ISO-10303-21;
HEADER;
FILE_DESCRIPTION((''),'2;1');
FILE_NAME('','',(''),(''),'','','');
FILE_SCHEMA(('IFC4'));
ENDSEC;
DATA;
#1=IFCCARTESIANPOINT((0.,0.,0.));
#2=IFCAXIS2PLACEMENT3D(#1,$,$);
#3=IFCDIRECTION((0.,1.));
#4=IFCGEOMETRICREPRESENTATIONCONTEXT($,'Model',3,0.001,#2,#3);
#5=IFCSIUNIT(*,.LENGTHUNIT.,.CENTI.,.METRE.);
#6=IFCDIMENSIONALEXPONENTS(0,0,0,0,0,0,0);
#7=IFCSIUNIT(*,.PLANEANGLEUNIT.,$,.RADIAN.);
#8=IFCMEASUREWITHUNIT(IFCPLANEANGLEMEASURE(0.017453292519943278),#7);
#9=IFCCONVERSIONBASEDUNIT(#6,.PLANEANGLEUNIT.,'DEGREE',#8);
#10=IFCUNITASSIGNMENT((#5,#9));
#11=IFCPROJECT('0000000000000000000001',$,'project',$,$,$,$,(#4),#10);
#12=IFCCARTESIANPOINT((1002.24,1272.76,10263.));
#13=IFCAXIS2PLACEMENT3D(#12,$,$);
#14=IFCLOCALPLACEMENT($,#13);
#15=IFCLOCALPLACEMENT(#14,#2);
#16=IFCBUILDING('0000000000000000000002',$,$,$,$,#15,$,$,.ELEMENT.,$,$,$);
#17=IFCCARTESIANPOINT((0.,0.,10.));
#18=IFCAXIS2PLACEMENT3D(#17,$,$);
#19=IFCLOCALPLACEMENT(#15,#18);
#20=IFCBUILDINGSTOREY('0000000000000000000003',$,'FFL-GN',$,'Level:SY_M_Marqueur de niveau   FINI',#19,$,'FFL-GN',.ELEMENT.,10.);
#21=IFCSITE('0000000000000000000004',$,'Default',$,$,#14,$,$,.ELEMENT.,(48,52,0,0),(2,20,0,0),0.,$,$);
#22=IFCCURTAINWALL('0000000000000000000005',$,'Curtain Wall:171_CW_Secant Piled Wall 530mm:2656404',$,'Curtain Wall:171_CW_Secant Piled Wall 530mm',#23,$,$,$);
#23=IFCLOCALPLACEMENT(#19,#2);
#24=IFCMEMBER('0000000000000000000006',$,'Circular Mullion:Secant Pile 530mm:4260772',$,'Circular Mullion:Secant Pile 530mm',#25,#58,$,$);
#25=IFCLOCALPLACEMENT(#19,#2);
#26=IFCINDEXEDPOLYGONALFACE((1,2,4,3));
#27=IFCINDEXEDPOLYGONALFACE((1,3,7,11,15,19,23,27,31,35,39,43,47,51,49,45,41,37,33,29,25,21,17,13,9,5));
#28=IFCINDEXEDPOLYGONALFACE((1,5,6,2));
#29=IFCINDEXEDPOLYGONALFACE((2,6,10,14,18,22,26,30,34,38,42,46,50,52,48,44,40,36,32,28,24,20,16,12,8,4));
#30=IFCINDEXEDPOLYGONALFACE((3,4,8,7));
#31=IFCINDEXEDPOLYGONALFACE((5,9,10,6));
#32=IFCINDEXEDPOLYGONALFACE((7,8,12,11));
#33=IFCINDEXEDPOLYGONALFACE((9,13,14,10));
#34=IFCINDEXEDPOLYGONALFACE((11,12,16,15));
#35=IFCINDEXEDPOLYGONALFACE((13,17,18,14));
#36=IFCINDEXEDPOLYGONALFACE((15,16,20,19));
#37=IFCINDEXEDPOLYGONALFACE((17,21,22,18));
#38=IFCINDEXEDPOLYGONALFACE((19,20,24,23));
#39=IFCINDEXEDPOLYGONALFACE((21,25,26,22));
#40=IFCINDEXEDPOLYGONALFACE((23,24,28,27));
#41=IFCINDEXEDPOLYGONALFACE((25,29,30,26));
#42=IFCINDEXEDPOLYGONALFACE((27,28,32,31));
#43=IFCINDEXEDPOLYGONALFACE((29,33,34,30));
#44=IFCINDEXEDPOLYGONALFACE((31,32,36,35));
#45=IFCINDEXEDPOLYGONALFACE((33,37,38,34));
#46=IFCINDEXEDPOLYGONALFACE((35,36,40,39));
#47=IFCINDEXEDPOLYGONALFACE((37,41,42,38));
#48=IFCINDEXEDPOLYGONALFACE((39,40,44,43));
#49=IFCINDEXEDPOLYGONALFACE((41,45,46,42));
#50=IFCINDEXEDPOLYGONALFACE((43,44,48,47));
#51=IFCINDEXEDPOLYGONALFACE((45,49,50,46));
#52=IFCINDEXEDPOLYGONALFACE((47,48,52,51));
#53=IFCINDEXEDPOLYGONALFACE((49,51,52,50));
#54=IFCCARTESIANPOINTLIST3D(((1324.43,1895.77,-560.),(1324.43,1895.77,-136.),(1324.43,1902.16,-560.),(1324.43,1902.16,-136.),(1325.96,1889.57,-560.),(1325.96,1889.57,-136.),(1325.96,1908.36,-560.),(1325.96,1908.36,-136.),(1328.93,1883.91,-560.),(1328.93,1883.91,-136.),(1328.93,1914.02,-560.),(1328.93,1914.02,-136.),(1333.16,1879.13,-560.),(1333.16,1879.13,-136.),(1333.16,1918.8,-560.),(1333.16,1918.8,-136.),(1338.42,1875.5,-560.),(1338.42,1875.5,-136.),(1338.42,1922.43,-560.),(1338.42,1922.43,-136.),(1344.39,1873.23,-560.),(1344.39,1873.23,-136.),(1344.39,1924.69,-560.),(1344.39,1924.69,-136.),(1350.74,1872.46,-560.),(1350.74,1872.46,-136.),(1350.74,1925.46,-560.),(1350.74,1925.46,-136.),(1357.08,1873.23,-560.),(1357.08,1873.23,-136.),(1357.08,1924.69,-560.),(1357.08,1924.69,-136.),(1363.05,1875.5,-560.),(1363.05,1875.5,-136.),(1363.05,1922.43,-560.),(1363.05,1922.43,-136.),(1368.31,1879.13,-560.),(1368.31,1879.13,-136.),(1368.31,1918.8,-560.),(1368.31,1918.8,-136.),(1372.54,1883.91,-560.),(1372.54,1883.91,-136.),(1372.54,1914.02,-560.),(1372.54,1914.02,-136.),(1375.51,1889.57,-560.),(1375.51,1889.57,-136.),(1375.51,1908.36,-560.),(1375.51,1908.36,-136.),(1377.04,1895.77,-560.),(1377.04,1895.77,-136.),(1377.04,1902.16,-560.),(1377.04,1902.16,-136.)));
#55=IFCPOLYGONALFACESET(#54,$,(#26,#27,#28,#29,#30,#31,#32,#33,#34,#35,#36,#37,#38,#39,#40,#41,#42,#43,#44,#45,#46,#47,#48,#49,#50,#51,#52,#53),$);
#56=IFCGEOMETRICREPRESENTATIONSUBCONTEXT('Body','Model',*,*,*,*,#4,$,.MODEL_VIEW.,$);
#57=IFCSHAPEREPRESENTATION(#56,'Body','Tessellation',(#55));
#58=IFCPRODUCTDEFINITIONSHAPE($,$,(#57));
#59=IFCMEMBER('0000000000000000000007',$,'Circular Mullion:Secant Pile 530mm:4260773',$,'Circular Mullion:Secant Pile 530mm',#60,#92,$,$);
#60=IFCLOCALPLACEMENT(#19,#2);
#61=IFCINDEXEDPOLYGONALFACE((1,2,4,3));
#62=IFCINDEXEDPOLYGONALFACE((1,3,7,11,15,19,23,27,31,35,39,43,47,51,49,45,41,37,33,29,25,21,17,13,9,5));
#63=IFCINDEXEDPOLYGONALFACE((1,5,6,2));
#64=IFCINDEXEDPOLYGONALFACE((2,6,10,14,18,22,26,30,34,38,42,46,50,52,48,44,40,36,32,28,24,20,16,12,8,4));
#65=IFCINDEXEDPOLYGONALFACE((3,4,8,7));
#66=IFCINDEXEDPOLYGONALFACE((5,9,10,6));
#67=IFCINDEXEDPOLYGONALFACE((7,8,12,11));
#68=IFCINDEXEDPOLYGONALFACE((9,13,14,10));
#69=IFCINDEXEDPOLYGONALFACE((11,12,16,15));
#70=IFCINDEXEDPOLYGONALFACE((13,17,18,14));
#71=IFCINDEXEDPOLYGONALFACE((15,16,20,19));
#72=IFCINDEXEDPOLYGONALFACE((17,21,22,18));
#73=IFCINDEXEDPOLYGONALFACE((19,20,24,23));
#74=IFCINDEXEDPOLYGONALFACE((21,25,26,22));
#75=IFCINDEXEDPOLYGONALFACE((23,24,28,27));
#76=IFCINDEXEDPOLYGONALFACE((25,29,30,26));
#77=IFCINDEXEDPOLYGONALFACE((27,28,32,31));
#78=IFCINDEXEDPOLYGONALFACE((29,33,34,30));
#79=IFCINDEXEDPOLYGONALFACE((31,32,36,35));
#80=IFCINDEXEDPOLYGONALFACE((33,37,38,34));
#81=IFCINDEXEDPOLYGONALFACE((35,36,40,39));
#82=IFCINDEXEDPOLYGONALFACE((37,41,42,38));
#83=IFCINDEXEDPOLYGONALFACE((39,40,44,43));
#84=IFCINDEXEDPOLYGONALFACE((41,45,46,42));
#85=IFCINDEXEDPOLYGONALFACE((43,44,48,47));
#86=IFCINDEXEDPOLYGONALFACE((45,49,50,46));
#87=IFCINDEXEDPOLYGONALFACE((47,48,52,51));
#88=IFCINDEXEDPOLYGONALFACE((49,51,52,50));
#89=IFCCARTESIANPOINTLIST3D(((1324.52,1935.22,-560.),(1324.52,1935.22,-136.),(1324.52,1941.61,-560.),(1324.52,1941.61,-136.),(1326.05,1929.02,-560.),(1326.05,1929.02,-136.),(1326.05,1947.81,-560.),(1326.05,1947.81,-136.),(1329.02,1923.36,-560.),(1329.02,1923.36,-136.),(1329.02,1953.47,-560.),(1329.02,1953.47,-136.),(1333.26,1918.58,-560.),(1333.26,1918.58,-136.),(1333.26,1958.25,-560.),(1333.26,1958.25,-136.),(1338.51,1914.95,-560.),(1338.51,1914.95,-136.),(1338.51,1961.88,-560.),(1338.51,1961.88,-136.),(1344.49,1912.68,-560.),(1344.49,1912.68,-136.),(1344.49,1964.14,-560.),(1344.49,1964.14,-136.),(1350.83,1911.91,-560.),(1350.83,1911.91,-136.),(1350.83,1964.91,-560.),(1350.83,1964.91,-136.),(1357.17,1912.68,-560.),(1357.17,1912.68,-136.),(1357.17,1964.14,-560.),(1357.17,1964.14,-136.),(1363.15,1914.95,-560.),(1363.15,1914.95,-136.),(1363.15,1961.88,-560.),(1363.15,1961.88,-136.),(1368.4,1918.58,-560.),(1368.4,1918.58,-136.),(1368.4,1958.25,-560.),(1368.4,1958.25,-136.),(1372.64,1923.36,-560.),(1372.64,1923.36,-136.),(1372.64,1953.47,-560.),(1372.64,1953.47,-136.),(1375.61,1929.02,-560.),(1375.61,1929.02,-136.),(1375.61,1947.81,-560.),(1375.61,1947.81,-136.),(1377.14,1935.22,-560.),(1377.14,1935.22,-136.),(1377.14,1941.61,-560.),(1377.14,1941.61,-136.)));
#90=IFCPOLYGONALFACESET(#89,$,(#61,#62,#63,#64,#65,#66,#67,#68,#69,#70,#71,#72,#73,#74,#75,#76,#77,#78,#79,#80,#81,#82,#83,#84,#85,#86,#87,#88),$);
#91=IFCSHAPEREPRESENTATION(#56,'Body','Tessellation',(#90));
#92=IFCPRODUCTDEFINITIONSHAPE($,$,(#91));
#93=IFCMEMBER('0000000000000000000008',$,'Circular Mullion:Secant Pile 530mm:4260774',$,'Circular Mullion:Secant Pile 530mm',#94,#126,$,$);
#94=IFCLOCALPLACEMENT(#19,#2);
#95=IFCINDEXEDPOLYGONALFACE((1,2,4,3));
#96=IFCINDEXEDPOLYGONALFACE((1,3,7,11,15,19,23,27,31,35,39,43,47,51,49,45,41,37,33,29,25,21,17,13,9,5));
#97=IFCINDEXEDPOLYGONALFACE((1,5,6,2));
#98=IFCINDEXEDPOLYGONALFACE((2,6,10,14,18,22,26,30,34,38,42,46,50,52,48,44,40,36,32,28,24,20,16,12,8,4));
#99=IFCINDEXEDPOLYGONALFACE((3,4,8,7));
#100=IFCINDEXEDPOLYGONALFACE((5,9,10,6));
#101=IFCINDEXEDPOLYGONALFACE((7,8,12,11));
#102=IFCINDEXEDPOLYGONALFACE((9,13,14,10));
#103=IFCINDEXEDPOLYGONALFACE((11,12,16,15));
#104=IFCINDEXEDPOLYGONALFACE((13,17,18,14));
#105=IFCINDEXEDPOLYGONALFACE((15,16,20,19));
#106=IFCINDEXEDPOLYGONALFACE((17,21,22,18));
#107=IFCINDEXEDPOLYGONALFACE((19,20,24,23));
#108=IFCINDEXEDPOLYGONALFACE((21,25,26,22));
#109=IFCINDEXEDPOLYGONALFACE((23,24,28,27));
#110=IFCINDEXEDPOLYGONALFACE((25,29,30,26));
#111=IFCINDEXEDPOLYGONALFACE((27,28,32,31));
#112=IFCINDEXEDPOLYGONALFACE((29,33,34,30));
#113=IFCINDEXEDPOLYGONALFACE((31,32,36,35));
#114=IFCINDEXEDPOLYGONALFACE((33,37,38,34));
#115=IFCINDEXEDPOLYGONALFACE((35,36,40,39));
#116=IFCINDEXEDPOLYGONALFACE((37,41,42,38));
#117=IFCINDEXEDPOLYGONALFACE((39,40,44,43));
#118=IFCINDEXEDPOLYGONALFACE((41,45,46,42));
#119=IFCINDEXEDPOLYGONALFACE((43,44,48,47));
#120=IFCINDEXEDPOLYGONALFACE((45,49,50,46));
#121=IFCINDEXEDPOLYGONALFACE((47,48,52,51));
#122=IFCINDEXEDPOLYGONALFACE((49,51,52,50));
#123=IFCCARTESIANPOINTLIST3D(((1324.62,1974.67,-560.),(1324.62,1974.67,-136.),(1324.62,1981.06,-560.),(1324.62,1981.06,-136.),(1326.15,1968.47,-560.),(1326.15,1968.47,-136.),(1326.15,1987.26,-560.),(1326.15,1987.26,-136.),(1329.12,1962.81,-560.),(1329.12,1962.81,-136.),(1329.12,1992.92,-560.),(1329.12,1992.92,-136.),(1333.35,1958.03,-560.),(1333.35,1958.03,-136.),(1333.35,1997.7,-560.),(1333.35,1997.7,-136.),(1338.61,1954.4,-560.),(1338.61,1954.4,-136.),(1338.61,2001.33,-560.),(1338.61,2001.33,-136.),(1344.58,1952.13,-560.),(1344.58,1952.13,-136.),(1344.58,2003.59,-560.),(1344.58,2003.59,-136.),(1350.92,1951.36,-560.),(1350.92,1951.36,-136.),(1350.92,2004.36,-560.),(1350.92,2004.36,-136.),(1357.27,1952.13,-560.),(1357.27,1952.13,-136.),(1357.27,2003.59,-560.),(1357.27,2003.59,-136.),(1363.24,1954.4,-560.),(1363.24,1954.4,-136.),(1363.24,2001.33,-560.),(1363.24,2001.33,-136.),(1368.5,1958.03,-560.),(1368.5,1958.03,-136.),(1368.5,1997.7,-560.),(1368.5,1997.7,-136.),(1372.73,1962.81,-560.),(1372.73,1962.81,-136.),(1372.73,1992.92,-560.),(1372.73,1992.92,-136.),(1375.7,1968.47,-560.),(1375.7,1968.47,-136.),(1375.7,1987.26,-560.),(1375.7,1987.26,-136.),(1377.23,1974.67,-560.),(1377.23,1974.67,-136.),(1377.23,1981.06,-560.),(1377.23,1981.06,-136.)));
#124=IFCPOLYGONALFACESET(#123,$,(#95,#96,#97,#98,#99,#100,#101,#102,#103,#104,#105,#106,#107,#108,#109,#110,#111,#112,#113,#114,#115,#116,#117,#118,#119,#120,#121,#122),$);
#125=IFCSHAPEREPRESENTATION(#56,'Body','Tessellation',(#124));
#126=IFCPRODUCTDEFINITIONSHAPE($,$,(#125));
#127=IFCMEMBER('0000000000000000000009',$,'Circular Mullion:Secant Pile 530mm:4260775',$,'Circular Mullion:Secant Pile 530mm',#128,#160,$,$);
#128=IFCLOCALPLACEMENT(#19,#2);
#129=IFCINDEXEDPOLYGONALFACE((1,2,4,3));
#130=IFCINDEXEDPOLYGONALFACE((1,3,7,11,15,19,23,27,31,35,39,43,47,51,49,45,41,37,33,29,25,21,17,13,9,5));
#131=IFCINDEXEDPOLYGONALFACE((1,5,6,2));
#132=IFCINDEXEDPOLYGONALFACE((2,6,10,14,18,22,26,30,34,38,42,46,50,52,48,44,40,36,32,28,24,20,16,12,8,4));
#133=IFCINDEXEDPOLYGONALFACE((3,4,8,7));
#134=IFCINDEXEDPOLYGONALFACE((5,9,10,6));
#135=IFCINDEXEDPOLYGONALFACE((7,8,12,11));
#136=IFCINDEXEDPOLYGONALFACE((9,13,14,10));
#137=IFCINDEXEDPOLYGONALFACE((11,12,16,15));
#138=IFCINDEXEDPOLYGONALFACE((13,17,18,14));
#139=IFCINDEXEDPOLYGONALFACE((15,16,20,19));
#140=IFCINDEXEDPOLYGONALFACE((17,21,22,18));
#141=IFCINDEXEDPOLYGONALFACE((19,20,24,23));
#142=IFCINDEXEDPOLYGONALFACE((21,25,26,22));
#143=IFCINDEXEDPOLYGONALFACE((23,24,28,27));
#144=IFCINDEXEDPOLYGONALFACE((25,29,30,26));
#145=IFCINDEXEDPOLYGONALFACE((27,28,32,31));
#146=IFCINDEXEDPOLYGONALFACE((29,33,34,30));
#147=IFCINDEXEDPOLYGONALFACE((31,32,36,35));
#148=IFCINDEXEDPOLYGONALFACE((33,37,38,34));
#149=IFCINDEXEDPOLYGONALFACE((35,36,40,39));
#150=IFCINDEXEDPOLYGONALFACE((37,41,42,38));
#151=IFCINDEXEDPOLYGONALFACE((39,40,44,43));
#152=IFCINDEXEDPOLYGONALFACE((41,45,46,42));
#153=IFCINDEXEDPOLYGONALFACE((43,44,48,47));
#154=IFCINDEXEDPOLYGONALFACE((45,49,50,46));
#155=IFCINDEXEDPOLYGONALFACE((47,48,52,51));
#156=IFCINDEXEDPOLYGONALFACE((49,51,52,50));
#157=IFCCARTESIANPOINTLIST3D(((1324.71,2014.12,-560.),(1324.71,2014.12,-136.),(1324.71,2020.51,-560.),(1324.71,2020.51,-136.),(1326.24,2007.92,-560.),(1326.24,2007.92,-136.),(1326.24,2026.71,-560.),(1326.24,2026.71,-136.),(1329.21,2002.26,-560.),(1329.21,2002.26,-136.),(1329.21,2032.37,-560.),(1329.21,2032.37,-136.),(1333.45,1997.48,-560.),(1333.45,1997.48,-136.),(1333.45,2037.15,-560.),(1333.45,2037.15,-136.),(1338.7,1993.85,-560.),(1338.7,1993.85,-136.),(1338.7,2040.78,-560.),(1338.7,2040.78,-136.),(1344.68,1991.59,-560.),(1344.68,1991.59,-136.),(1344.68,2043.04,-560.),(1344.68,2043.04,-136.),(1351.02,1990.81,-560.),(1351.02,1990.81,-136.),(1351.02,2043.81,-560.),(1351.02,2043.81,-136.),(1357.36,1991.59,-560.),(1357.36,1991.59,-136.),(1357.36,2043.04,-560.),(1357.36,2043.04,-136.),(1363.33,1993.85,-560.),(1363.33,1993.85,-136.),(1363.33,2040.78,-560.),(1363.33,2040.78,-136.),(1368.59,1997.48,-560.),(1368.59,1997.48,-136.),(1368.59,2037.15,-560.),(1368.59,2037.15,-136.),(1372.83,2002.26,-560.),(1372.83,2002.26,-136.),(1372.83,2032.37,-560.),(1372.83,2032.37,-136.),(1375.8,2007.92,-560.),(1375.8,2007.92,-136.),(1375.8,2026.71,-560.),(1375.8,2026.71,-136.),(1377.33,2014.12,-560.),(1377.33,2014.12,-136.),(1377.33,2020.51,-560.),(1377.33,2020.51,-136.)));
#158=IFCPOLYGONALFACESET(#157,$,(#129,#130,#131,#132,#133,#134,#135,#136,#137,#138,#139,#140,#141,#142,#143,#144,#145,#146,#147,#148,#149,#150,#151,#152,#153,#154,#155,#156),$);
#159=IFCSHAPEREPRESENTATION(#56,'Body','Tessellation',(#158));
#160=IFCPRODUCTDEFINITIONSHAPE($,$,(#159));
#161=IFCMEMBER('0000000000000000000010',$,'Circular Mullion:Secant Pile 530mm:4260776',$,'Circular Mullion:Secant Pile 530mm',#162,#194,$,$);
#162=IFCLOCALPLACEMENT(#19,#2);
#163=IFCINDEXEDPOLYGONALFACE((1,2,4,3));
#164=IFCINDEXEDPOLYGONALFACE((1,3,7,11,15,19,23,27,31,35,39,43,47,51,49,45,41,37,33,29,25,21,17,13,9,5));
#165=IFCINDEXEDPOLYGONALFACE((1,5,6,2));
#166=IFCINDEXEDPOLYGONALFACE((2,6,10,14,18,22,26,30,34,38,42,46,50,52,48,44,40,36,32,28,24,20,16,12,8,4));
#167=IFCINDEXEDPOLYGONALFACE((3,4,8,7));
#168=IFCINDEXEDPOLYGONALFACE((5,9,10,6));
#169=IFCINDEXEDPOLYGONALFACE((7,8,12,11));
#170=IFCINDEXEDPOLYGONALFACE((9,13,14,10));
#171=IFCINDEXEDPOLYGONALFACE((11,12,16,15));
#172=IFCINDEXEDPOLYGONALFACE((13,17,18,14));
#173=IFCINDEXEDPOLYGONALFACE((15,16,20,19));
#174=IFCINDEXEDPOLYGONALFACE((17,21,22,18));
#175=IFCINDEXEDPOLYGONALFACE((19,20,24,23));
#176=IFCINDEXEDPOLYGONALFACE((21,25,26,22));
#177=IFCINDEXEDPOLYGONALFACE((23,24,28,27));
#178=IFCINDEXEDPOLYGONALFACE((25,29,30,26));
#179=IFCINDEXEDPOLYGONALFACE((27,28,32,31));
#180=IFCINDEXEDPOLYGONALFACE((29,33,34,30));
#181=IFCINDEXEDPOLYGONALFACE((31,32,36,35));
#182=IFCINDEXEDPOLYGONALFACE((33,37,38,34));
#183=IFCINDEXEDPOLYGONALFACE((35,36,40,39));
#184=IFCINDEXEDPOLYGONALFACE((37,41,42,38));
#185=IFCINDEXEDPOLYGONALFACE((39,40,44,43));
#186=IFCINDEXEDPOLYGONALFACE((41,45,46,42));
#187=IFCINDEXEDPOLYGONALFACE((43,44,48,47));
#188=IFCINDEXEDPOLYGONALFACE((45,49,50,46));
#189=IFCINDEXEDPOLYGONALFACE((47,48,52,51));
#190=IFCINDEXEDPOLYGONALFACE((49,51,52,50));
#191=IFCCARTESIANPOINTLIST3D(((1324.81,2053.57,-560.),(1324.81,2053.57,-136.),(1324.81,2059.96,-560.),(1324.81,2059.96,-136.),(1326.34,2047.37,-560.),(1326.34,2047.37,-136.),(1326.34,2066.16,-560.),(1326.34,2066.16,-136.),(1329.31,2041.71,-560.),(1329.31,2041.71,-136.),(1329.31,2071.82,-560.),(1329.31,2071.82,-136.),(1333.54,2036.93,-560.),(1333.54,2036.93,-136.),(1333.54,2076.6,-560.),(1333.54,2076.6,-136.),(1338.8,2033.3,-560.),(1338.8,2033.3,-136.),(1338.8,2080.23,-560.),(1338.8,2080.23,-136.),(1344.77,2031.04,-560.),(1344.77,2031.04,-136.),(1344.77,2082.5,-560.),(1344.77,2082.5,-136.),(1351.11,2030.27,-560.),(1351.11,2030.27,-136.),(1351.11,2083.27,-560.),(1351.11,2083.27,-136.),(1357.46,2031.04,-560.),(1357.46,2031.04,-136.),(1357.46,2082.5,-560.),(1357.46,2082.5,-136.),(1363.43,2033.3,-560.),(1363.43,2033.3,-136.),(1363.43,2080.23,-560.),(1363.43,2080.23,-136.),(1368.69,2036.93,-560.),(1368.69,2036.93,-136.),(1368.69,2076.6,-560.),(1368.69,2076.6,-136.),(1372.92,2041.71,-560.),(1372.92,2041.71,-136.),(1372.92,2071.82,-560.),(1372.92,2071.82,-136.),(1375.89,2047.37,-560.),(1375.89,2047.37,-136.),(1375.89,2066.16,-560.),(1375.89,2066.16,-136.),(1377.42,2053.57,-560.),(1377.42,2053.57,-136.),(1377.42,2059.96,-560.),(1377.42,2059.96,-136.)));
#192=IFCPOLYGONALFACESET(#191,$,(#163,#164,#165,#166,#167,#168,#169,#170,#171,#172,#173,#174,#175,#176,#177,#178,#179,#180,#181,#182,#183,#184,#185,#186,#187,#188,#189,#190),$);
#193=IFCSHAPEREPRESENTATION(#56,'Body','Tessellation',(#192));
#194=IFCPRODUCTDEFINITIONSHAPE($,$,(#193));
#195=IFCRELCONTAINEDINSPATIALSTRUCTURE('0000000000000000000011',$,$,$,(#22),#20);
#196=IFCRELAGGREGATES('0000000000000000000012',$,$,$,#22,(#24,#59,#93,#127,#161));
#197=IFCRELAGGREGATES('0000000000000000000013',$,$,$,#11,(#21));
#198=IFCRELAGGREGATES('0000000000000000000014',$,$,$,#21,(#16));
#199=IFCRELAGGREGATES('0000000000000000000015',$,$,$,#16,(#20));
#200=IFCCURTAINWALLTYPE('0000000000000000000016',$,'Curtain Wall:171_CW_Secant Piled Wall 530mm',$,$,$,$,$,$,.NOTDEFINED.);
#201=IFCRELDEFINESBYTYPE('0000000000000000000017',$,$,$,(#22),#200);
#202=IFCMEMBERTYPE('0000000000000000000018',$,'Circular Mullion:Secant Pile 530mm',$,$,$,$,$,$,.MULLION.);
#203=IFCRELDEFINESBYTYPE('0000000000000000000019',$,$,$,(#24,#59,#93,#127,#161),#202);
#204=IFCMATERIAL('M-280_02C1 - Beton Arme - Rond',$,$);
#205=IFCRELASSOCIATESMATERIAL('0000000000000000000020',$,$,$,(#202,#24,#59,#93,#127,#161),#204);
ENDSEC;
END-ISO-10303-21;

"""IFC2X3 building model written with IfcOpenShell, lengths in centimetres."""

from ifc_helpers import new_model, entity, si_unit, converted_unit, direction, frame, frame_2d, origin, place, context, subcontext, project, spatial, circle, extrude, source, transform, mapped, material, type_object, type_shapes, element, aggregate, save


model = new_model("IFC2X3")

# Units and contexts
model_context = context("Model", 3, precision=0.001, world=origin(), true_north=direction((0.0, 1.0)))
body_context = subcontext(model_context, "Body", "Model", "MODEL_VIEW")
ifc_project = project(units=[si_unit("LENGTHUNIT", "METRE", prefix="CENTI"), converted_unit("PLANEANGLEUNIT", "DEGREE", entity("IfcPlaneAngleMeasure", 0.017453292519943278), si_unit("PLANEANGLEUNIT", "RADIAN"), dimensions=[0, 0, 0, 0, 0, 0, 0])], contexts=[model_context])

# Site, building, storey
site_placement = place(None, frame((1002.24, 1272.76, 10263.0)))
site = spatial("IfcSite", under=ifc_project, at=site_placement, Name="Default", CompositionType="ELEMENT", RefLatitude=(48, 52, 0, 0), RefLongitude=(2, 20, 0, 0), RefElevation=0.0)
building_placement = place(site_placement, origin())
building = spatial("IfcBuilding", under=site, at=building_placement, CompositionType="ELEMENT")
storey_placement = place(building_placement, frame((0.0, 0.0, 10.0)))
storey = spatial("IfcBuildingStorey", under=building, at=storey_placement, Name="FFL-GN", ObjectType="Level:SY_M_Marqueur de niveau   FINI", LongName="FFL-GN", CompositionType="ELEMENT", Elevation=10.0)

# Curtain wall, members
curtain_wall_type = type_object("IfcCurtainWallType", Name="Curtain Wall:171_CW_Secant Piled Wall 530mm", PredefinedType="NOTDEFINED")
curtain_wall_1_placement = place(storey_placement, frame((0.0, 0.0, -10.0)))
curtain_wall_1 = element("IfcCurtainWall", 1, at=curtain_wall_1_placement, inside=storey, type_object=curtain_wall_type, Name="Curtain Wall:171_CW_Secant Piled Wall 530mm:2656404", ObjectType="Curtain Wall:171_CW_Secant Piled Wall 530mm")
ifc_material_1 = material(Name="M-280_02C1 - Beton Arme - Rond")
member_type = type_object("IfcMemberType", Name="Circular Mullion:Secant Pile 530mm", PredefinedType="MULLION", material=ifc_material_1)
shared_shape = source(origin(), body_context, "Body", "SweptSolid", [
    extrude(circle(Radius=26.5, at=frame_2d((0.0, 0.0), x_axis=(1.0, 0.0))), frame((0.0, 0.0, -424.0)), (0.0, 0.0, 1.0), 424.0),
])
type_shapes(member_type, [shared_shape])
member_1_placement = place(curtain_wall_1_placement, frame((1350.74, 1898.96, -550.0), z_axis=(0.0, 0.0, -1.0), x_axis=(0.0, 1.0, 0.0)))
member_1 = element("IfcMember", 2, at=member_1_placement, type_object=member_type, material=ifc_material_1, Name="Circular Mullion:Secant Pile 530mm:4260772", ObjectType="Circular Mullion:Secant Pile 530mm", context=body_context, shape_type="MappedRepresentation", body=[
    mapped(shared_shape, transform((0.0, 0.0, 0.0), scale=1.0)),
])
member_2_placement = place(curtain_wall_1_placement, frame((1350.83, 1938.41, -550.0), z_axis=(0.0, 0.0, -1.0), x_axis=(0.0, 1.0, 0.0)))
member_2 = element("IfcMember", 3, at=member_2_placement, type_object=member_type, material=ifc_material_1, Name="Circular Mullion:Secant Pile 530mm:4260773", ObjectType="Circular Mullion:Secant Pile 530mm", context=body_context, shape_type="MappedRepresentation", body=[
    mapped(shared_shape, transform((0.0, 0.0, 0.0), scale=1.0)),
])
member_3_placement = place(curtain_wall_1_placement, frame((1350.92, 1977.86, -550.0), z_axis=(0.0, 0.0, -1.0), x_axis=(0.0, 1.0, 0.0)))
member_3 = element("IfcMember", 4, at=member_3_placement, type_object=member_type, material=ifc_material_1, Name="Circular Mullion:Secant Pile 530mm:4260774", ObjectType="Circular Mullion:Secant Pile 530mm", context=body_context, shape_type="MappedRepresentation", body=[
    mapped(shared_shape, transform((0.0, 0.0, 0.0), scale=1.0)),
])
member_4_placement = place(curtain_wall_1_placement, frame((1351.02, 2017.31, -550.0), z_axis=(0.0, 0.0, -1.0), x_axis=(0.0, 1.0, 0.0)))
member_4 = element("IfcMember", 5, at=member_4_placement, type_object=member_type, material=ifc_material_1, Name="Circular Mullion:Secant Pile 530mm:4260775", ObjectType="Circular Mullion:Secant Pile 530mm", context=body_context, shape_type="MappedRepresentation", body=[
    mapped(shared_shape, transform((0.0, 0.0, 0.0), scale=1.0)),
])
member_5_placement = place(curtain_wall_1_placement, frame((1351.11, 2056.77, -550.0), z_axis=(0.0, 0.0, -1.0), x_axis=(0.0, 1.0, 0.0)))
member_5 = element("IfcMember", 6, at=member_5_placement, type_object=member_type, material=ifc_material_1, Name="Circular Mullion:Secant Pile 530mm:4260776", ObjectType="Circular Mullion:Secant Pile 530mm", context=body_context, shape_type="MappedRepresentation", body=[
    mapped(shared_shape, transform((0.0, 0.0, 0.0), scale=1.0)),
])
aggregate(curtain_wall_1, [member_1, member_2, member_3, member_4, member_5])

save(model, "model.ifc")
